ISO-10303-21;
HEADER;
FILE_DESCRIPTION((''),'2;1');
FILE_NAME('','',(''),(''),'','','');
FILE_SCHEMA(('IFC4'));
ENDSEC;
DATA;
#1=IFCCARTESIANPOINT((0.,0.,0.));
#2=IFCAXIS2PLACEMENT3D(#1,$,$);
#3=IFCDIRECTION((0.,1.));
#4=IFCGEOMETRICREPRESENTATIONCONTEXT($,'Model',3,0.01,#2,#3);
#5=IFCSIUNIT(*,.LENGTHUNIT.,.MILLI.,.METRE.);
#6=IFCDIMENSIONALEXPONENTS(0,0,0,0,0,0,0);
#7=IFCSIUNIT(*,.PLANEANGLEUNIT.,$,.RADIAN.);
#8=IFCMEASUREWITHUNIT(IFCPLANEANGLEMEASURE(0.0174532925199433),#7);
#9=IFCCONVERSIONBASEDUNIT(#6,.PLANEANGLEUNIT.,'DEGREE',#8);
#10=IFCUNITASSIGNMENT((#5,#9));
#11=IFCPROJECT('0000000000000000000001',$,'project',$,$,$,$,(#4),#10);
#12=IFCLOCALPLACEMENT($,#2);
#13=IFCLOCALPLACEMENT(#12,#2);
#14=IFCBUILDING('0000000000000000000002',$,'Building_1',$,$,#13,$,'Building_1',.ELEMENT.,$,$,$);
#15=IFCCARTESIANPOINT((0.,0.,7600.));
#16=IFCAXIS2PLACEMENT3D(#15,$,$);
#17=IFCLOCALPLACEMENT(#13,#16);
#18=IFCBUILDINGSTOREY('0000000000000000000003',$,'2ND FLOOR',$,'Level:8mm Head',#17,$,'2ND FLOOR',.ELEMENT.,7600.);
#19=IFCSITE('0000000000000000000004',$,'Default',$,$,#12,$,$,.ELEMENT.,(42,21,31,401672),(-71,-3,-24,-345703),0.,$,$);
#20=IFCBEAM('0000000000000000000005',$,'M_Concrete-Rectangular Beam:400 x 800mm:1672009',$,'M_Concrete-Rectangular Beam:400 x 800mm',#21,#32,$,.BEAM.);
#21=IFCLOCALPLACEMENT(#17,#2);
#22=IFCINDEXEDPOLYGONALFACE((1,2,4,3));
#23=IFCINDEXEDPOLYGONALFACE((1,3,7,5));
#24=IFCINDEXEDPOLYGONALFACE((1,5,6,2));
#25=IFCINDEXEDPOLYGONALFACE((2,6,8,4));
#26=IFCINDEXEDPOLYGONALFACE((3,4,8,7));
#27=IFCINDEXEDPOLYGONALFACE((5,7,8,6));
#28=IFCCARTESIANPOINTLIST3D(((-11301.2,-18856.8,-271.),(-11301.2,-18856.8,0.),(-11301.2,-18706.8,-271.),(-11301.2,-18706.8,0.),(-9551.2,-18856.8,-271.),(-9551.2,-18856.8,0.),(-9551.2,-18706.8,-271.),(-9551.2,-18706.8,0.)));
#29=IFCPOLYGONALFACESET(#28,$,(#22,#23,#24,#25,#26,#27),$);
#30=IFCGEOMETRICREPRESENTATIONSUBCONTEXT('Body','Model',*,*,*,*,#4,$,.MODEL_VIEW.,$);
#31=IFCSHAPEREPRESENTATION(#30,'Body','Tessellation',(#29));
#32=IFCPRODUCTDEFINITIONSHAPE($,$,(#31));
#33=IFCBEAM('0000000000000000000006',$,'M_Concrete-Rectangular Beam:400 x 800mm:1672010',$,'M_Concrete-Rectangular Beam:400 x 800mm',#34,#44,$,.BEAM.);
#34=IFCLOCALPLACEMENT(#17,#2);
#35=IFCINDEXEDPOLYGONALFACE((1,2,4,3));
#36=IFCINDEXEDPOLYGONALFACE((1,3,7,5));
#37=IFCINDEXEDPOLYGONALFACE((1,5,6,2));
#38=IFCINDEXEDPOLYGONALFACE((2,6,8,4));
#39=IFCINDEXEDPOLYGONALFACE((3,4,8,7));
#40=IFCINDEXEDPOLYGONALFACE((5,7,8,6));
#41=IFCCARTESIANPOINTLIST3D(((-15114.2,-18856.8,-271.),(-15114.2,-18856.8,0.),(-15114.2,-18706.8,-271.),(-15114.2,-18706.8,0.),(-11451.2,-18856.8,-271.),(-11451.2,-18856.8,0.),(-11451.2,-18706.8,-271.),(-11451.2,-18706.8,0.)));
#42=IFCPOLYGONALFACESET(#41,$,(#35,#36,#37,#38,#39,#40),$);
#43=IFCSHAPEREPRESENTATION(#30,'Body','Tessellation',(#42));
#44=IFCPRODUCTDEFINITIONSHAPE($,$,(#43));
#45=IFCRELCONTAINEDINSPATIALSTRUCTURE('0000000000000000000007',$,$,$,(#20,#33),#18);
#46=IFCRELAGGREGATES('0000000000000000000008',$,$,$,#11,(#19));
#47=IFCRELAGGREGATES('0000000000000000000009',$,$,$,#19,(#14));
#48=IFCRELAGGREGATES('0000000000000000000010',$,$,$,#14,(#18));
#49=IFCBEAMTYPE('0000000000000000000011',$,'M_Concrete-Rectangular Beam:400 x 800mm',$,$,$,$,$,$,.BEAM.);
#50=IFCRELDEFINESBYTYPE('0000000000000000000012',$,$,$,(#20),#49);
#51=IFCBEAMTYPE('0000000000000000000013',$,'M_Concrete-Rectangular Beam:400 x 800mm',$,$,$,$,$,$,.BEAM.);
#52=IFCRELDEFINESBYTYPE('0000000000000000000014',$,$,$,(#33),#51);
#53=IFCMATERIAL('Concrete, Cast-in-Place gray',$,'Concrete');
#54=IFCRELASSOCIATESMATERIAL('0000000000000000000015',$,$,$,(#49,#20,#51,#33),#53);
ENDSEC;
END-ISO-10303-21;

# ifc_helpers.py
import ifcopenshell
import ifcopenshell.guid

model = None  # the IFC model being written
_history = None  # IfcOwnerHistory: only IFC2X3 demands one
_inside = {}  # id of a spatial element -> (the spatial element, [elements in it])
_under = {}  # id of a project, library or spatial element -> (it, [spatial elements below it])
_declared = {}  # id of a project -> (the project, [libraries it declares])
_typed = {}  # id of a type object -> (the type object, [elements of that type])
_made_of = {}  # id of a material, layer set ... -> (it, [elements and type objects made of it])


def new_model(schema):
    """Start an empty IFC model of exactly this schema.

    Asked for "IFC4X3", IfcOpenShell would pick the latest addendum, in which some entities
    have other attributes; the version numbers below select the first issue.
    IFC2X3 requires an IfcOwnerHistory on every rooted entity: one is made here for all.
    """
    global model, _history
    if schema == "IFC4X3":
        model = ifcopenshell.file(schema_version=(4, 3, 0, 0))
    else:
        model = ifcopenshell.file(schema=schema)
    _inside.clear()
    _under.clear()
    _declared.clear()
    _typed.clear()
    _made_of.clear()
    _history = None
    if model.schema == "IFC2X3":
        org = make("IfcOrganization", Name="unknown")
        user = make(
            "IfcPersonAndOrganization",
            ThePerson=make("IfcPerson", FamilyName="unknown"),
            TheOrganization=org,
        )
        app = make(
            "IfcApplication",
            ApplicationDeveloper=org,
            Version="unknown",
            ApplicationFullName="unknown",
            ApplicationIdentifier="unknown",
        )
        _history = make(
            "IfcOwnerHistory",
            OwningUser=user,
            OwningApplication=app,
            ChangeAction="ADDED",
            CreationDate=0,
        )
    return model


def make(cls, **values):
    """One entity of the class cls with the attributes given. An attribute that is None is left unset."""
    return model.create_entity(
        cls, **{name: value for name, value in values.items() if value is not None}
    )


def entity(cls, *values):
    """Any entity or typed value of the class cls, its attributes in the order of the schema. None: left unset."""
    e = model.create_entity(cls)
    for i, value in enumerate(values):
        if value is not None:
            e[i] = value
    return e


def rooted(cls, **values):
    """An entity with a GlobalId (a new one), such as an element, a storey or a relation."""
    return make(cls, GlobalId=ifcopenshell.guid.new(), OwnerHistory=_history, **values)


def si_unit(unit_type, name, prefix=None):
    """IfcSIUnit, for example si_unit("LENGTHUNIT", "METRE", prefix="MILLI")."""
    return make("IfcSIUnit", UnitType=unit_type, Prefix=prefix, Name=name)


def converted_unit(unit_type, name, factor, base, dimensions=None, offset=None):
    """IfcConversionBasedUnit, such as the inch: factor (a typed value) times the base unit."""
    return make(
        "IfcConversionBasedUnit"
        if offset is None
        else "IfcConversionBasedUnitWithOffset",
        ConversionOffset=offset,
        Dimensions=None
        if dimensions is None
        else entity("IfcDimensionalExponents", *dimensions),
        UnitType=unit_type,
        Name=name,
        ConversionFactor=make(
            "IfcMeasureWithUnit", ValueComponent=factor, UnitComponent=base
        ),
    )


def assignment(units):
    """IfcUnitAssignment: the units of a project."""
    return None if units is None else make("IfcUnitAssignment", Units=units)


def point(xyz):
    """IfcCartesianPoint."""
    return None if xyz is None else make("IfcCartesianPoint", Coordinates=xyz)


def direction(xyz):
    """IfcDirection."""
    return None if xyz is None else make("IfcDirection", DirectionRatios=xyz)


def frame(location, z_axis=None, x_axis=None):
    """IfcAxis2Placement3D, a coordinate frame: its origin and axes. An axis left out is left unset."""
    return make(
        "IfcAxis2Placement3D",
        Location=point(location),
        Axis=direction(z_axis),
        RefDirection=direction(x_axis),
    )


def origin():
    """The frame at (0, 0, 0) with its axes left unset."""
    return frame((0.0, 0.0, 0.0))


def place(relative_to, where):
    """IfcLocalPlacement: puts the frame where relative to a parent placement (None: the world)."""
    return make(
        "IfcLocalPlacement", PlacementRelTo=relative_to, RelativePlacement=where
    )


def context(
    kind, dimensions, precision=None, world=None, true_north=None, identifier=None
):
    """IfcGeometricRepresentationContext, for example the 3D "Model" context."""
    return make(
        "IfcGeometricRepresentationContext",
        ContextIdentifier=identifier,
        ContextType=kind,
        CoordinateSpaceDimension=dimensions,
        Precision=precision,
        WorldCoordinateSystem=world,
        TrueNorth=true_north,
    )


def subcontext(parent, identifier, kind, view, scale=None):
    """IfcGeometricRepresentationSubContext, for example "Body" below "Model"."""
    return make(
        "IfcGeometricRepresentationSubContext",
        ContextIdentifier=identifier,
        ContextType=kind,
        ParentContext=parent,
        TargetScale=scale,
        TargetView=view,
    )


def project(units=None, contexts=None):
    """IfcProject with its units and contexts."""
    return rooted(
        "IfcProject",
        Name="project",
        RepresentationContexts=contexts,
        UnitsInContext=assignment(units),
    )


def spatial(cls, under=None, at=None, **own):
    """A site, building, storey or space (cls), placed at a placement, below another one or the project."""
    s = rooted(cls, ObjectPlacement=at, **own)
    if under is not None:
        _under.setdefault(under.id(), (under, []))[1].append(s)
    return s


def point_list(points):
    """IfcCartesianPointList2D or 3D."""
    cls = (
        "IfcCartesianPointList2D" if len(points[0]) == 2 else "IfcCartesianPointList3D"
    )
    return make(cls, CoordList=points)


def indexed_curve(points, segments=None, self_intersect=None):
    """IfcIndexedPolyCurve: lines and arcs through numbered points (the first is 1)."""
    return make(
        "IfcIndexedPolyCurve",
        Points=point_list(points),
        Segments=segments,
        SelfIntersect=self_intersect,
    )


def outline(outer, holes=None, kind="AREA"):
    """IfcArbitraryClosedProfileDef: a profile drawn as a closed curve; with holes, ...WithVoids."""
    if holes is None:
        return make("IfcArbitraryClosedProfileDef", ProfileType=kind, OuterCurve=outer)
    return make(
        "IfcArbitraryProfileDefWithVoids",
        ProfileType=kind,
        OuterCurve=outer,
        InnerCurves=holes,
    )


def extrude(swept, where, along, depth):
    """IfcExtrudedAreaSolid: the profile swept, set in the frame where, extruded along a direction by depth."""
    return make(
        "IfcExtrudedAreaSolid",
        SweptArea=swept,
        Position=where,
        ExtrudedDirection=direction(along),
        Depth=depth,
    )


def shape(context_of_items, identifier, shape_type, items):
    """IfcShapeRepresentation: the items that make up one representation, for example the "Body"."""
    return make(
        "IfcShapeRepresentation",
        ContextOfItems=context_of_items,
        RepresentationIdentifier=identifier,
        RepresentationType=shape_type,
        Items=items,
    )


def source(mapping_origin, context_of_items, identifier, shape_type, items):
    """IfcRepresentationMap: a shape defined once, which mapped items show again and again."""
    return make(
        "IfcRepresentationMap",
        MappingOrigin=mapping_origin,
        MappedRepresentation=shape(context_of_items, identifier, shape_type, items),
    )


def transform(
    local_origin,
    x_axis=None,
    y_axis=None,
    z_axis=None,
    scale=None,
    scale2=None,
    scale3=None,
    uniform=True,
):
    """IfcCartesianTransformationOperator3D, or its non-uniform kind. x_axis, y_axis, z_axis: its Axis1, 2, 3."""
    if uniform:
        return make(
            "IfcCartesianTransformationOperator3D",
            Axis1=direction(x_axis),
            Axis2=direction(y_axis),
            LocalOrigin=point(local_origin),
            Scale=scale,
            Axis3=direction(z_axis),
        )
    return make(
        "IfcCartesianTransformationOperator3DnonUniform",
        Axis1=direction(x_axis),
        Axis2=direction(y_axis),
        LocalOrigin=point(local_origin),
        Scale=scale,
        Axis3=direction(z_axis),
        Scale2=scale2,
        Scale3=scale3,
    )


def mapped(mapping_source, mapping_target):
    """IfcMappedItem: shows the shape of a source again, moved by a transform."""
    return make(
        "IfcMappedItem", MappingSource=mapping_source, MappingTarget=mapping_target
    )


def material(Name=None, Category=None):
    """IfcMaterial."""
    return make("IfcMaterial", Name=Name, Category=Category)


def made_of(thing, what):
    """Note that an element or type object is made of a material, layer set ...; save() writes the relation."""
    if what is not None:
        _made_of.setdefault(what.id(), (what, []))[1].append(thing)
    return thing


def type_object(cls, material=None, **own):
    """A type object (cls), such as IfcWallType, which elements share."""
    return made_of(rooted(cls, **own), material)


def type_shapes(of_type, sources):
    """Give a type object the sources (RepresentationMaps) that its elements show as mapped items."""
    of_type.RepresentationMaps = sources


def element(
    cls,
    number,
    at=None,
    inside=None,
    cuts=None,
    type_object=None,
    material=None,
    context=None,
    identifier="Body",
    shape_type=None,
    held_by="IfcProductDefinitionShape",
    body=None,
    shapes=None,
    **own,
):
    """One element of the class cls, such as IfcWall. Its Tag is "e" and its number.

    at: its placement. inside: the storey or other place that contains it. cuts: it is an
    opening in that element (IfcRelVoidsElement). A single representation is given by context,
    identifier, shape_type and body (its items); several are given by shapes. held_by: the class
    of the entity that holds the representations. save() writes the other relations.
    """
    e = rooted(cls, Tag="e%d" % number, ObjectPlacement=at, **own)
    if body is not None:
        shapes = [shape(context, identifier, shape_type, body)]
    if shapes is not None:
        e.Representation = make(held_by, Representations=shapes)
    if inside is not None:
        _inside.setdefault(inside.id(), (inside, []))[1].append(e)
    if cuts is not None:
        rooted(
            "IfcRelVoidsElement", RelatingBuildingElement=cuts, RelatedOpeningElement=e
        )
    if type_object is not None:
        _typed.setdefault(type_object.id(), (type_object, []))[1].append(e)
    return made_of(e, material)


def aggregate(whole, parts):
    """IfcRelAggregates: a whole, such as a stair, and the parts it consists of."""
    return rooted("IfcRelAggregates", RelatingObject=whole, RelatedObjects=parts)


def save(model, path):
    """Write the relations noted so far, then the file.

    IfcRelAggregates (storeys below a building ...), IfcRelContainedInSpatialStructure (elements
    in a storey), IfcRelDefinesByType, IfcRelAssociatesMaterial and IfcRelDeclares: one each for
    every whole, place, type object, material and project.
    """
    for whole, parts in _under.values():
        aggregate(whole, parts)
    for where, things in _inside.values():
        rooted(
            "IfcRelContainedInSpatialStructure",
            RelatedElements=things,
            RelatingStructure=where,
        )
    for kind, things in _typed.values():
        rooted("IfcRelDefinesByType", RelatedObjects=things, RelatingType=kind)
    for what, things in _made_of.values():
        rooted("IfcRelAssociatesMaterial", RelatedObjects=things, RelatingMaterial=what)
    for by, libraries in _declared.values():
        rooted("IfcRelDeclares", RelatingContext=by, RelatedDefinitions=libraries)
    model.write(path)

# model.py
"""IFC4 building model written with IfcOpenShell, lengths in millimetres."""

from ifc_helpers import new_model, entity, si_unit, converted_unit, direction, frame, origin, place, context, subcontext, project, spatial, indexed_curve, outline, extrude, source, transform, mapped, material, type_object, type_shapes, element, save


model = new_model("IFC4")

# Units and contexts
model_context = context("Model", 3, precision=0.01, world=origin(), true_north=direction((0.0, 1.0)))
body_context = subcontext(model_context, "Body", "Model", "MODEL_VIEW")
ifc_project = project(units=[si_unit("LENGTHUNIT", "METRE", prefix="MILLI"), converted_unit("PLANEANGLEUNIT", "DEGREE", entity("IfcPlaneAngleMeasure", 0.0174532925199433), si_unit("PLANEANGLEUNIT", "RADIAN"), dimensions=[0, 0, 0, 0, 0, 0, 0])], contexts=[model_context])

# Site, building, storey
site_placement = place(None, origin())
site = spatial("IfcSite", under=ifc_project, at=site_placement, Name="Default", CompositionType="ELEMENT", RefLatitude=(42, 21, 31, 401672), RefLongitude=(-71, -3, -24, -345703), RefElevation=0.0)
building_placement = place(site_placement, origin())
building = spatial("IfcBuilding", under=site, at=building_placement, Name="Building_1", LongName="Building_1", CompositionType="ELEMENT")
storey_placement = place(building_placement, frame((0.0, 0.0, 7600.0)))
storey = spatial("IfcBuildingStorey", under=building, at=storey_placement, Name="2ND FLOOR", ObjectType="Level:8mm Head", LongName="2ND FLOOR", CompositionType="ELEMENT", Elevation=7600.0)

# Beams
ifc_material = material(Name="Concrete, Cast-in-Place gray", Category="Concrete")
beam_type_1 = type_object("IfcBeamType", Name="M_Concrete-Rectangular Beam:400 x 800mm", PredefinedType="BEAM", material=ifc_material)
shared_shape_1 = source(origin(), body_context, "Body", "SweptSolid", [
    extrude(outline(indexed_curve([(-135.5, -75.0), (135.5, -75.0), (135.5, 75.0), (-135.5, 75.0), (-135.5, -75.0)], self_intersect=False)), frame((-9551.2, -18781.8, 7464.5), z_axis=(-1.0, 0.0, 0.0), x_axis=(0.0, 0.0, -1.0)), (0.0, 0.0, 1.0), 1750.0),
])
type_shapes(beam_type_1, [shared_shape_1])
beam_1_placement = place(storey_placement, frame((0.0, 0.0, -7600.0)))
element("IfcBeam", 1, at=beam_1_placement, inside=storey, type_object=beam_type_1, material=ifc_material, Name="M_Concrete-Rectangular Beam:400 x 800mm:1672009", ObjectType="M_Concrete-Rectangular Beam:400 x 800mm", PredefinedType="BEAM", context=body_context, shape_type="MappedRepresentation", body=[
    mapped(shared_shape_1, transform((0.0, 0.0, 0.0), scale=1.0)),
])
beam_type_2 = type_object("IfcBeamType", Name="M_Concrete-Rectangular Beam:400 x 800mm", PredefinedType="BEAM", material=ifc_material)
shared_shape_2 = source(origin(), body_context, "Body", "SweptSolid", [
    extrude(outline(indexed_curve([(-135.5, -75.0), (135.5, -75.0), (135.5, 75.0), (-135.5, 75.0), (-135.5, -75.0)], self_intersect=False)), frame((-11451.2, -18781.8, 7464.5), z_axis=(-1.0, 0.0, 0.0), x_axis=(0.0, 0.0, -1.0)), (0.0, 0.0, 1.0), 3663.0),
])
type_shapes(beam_type_2, [shared_shape_2])
beam_2_placement = place(storey_placement, frame((0.0, 0.0, -7600.0)))
element("IfcBeam", 2, at=beam_2_placement, inside=storey, type_object=beam_type_2, material=ifc_material, Name="M_Concrete-Rectangular Beam:400 x 800mm:1672010", ObjectType="M_Concrete-Rectangular Beam:400 x 800mm", PredefinedType="BEAM", context=body_context, shape_type="MappedRepresentation", body=[
    mapped(shared_shape_2, transform((0.0, 0.0, 0.0), scale=1.0)),
])

save(model, "model.ifc")
